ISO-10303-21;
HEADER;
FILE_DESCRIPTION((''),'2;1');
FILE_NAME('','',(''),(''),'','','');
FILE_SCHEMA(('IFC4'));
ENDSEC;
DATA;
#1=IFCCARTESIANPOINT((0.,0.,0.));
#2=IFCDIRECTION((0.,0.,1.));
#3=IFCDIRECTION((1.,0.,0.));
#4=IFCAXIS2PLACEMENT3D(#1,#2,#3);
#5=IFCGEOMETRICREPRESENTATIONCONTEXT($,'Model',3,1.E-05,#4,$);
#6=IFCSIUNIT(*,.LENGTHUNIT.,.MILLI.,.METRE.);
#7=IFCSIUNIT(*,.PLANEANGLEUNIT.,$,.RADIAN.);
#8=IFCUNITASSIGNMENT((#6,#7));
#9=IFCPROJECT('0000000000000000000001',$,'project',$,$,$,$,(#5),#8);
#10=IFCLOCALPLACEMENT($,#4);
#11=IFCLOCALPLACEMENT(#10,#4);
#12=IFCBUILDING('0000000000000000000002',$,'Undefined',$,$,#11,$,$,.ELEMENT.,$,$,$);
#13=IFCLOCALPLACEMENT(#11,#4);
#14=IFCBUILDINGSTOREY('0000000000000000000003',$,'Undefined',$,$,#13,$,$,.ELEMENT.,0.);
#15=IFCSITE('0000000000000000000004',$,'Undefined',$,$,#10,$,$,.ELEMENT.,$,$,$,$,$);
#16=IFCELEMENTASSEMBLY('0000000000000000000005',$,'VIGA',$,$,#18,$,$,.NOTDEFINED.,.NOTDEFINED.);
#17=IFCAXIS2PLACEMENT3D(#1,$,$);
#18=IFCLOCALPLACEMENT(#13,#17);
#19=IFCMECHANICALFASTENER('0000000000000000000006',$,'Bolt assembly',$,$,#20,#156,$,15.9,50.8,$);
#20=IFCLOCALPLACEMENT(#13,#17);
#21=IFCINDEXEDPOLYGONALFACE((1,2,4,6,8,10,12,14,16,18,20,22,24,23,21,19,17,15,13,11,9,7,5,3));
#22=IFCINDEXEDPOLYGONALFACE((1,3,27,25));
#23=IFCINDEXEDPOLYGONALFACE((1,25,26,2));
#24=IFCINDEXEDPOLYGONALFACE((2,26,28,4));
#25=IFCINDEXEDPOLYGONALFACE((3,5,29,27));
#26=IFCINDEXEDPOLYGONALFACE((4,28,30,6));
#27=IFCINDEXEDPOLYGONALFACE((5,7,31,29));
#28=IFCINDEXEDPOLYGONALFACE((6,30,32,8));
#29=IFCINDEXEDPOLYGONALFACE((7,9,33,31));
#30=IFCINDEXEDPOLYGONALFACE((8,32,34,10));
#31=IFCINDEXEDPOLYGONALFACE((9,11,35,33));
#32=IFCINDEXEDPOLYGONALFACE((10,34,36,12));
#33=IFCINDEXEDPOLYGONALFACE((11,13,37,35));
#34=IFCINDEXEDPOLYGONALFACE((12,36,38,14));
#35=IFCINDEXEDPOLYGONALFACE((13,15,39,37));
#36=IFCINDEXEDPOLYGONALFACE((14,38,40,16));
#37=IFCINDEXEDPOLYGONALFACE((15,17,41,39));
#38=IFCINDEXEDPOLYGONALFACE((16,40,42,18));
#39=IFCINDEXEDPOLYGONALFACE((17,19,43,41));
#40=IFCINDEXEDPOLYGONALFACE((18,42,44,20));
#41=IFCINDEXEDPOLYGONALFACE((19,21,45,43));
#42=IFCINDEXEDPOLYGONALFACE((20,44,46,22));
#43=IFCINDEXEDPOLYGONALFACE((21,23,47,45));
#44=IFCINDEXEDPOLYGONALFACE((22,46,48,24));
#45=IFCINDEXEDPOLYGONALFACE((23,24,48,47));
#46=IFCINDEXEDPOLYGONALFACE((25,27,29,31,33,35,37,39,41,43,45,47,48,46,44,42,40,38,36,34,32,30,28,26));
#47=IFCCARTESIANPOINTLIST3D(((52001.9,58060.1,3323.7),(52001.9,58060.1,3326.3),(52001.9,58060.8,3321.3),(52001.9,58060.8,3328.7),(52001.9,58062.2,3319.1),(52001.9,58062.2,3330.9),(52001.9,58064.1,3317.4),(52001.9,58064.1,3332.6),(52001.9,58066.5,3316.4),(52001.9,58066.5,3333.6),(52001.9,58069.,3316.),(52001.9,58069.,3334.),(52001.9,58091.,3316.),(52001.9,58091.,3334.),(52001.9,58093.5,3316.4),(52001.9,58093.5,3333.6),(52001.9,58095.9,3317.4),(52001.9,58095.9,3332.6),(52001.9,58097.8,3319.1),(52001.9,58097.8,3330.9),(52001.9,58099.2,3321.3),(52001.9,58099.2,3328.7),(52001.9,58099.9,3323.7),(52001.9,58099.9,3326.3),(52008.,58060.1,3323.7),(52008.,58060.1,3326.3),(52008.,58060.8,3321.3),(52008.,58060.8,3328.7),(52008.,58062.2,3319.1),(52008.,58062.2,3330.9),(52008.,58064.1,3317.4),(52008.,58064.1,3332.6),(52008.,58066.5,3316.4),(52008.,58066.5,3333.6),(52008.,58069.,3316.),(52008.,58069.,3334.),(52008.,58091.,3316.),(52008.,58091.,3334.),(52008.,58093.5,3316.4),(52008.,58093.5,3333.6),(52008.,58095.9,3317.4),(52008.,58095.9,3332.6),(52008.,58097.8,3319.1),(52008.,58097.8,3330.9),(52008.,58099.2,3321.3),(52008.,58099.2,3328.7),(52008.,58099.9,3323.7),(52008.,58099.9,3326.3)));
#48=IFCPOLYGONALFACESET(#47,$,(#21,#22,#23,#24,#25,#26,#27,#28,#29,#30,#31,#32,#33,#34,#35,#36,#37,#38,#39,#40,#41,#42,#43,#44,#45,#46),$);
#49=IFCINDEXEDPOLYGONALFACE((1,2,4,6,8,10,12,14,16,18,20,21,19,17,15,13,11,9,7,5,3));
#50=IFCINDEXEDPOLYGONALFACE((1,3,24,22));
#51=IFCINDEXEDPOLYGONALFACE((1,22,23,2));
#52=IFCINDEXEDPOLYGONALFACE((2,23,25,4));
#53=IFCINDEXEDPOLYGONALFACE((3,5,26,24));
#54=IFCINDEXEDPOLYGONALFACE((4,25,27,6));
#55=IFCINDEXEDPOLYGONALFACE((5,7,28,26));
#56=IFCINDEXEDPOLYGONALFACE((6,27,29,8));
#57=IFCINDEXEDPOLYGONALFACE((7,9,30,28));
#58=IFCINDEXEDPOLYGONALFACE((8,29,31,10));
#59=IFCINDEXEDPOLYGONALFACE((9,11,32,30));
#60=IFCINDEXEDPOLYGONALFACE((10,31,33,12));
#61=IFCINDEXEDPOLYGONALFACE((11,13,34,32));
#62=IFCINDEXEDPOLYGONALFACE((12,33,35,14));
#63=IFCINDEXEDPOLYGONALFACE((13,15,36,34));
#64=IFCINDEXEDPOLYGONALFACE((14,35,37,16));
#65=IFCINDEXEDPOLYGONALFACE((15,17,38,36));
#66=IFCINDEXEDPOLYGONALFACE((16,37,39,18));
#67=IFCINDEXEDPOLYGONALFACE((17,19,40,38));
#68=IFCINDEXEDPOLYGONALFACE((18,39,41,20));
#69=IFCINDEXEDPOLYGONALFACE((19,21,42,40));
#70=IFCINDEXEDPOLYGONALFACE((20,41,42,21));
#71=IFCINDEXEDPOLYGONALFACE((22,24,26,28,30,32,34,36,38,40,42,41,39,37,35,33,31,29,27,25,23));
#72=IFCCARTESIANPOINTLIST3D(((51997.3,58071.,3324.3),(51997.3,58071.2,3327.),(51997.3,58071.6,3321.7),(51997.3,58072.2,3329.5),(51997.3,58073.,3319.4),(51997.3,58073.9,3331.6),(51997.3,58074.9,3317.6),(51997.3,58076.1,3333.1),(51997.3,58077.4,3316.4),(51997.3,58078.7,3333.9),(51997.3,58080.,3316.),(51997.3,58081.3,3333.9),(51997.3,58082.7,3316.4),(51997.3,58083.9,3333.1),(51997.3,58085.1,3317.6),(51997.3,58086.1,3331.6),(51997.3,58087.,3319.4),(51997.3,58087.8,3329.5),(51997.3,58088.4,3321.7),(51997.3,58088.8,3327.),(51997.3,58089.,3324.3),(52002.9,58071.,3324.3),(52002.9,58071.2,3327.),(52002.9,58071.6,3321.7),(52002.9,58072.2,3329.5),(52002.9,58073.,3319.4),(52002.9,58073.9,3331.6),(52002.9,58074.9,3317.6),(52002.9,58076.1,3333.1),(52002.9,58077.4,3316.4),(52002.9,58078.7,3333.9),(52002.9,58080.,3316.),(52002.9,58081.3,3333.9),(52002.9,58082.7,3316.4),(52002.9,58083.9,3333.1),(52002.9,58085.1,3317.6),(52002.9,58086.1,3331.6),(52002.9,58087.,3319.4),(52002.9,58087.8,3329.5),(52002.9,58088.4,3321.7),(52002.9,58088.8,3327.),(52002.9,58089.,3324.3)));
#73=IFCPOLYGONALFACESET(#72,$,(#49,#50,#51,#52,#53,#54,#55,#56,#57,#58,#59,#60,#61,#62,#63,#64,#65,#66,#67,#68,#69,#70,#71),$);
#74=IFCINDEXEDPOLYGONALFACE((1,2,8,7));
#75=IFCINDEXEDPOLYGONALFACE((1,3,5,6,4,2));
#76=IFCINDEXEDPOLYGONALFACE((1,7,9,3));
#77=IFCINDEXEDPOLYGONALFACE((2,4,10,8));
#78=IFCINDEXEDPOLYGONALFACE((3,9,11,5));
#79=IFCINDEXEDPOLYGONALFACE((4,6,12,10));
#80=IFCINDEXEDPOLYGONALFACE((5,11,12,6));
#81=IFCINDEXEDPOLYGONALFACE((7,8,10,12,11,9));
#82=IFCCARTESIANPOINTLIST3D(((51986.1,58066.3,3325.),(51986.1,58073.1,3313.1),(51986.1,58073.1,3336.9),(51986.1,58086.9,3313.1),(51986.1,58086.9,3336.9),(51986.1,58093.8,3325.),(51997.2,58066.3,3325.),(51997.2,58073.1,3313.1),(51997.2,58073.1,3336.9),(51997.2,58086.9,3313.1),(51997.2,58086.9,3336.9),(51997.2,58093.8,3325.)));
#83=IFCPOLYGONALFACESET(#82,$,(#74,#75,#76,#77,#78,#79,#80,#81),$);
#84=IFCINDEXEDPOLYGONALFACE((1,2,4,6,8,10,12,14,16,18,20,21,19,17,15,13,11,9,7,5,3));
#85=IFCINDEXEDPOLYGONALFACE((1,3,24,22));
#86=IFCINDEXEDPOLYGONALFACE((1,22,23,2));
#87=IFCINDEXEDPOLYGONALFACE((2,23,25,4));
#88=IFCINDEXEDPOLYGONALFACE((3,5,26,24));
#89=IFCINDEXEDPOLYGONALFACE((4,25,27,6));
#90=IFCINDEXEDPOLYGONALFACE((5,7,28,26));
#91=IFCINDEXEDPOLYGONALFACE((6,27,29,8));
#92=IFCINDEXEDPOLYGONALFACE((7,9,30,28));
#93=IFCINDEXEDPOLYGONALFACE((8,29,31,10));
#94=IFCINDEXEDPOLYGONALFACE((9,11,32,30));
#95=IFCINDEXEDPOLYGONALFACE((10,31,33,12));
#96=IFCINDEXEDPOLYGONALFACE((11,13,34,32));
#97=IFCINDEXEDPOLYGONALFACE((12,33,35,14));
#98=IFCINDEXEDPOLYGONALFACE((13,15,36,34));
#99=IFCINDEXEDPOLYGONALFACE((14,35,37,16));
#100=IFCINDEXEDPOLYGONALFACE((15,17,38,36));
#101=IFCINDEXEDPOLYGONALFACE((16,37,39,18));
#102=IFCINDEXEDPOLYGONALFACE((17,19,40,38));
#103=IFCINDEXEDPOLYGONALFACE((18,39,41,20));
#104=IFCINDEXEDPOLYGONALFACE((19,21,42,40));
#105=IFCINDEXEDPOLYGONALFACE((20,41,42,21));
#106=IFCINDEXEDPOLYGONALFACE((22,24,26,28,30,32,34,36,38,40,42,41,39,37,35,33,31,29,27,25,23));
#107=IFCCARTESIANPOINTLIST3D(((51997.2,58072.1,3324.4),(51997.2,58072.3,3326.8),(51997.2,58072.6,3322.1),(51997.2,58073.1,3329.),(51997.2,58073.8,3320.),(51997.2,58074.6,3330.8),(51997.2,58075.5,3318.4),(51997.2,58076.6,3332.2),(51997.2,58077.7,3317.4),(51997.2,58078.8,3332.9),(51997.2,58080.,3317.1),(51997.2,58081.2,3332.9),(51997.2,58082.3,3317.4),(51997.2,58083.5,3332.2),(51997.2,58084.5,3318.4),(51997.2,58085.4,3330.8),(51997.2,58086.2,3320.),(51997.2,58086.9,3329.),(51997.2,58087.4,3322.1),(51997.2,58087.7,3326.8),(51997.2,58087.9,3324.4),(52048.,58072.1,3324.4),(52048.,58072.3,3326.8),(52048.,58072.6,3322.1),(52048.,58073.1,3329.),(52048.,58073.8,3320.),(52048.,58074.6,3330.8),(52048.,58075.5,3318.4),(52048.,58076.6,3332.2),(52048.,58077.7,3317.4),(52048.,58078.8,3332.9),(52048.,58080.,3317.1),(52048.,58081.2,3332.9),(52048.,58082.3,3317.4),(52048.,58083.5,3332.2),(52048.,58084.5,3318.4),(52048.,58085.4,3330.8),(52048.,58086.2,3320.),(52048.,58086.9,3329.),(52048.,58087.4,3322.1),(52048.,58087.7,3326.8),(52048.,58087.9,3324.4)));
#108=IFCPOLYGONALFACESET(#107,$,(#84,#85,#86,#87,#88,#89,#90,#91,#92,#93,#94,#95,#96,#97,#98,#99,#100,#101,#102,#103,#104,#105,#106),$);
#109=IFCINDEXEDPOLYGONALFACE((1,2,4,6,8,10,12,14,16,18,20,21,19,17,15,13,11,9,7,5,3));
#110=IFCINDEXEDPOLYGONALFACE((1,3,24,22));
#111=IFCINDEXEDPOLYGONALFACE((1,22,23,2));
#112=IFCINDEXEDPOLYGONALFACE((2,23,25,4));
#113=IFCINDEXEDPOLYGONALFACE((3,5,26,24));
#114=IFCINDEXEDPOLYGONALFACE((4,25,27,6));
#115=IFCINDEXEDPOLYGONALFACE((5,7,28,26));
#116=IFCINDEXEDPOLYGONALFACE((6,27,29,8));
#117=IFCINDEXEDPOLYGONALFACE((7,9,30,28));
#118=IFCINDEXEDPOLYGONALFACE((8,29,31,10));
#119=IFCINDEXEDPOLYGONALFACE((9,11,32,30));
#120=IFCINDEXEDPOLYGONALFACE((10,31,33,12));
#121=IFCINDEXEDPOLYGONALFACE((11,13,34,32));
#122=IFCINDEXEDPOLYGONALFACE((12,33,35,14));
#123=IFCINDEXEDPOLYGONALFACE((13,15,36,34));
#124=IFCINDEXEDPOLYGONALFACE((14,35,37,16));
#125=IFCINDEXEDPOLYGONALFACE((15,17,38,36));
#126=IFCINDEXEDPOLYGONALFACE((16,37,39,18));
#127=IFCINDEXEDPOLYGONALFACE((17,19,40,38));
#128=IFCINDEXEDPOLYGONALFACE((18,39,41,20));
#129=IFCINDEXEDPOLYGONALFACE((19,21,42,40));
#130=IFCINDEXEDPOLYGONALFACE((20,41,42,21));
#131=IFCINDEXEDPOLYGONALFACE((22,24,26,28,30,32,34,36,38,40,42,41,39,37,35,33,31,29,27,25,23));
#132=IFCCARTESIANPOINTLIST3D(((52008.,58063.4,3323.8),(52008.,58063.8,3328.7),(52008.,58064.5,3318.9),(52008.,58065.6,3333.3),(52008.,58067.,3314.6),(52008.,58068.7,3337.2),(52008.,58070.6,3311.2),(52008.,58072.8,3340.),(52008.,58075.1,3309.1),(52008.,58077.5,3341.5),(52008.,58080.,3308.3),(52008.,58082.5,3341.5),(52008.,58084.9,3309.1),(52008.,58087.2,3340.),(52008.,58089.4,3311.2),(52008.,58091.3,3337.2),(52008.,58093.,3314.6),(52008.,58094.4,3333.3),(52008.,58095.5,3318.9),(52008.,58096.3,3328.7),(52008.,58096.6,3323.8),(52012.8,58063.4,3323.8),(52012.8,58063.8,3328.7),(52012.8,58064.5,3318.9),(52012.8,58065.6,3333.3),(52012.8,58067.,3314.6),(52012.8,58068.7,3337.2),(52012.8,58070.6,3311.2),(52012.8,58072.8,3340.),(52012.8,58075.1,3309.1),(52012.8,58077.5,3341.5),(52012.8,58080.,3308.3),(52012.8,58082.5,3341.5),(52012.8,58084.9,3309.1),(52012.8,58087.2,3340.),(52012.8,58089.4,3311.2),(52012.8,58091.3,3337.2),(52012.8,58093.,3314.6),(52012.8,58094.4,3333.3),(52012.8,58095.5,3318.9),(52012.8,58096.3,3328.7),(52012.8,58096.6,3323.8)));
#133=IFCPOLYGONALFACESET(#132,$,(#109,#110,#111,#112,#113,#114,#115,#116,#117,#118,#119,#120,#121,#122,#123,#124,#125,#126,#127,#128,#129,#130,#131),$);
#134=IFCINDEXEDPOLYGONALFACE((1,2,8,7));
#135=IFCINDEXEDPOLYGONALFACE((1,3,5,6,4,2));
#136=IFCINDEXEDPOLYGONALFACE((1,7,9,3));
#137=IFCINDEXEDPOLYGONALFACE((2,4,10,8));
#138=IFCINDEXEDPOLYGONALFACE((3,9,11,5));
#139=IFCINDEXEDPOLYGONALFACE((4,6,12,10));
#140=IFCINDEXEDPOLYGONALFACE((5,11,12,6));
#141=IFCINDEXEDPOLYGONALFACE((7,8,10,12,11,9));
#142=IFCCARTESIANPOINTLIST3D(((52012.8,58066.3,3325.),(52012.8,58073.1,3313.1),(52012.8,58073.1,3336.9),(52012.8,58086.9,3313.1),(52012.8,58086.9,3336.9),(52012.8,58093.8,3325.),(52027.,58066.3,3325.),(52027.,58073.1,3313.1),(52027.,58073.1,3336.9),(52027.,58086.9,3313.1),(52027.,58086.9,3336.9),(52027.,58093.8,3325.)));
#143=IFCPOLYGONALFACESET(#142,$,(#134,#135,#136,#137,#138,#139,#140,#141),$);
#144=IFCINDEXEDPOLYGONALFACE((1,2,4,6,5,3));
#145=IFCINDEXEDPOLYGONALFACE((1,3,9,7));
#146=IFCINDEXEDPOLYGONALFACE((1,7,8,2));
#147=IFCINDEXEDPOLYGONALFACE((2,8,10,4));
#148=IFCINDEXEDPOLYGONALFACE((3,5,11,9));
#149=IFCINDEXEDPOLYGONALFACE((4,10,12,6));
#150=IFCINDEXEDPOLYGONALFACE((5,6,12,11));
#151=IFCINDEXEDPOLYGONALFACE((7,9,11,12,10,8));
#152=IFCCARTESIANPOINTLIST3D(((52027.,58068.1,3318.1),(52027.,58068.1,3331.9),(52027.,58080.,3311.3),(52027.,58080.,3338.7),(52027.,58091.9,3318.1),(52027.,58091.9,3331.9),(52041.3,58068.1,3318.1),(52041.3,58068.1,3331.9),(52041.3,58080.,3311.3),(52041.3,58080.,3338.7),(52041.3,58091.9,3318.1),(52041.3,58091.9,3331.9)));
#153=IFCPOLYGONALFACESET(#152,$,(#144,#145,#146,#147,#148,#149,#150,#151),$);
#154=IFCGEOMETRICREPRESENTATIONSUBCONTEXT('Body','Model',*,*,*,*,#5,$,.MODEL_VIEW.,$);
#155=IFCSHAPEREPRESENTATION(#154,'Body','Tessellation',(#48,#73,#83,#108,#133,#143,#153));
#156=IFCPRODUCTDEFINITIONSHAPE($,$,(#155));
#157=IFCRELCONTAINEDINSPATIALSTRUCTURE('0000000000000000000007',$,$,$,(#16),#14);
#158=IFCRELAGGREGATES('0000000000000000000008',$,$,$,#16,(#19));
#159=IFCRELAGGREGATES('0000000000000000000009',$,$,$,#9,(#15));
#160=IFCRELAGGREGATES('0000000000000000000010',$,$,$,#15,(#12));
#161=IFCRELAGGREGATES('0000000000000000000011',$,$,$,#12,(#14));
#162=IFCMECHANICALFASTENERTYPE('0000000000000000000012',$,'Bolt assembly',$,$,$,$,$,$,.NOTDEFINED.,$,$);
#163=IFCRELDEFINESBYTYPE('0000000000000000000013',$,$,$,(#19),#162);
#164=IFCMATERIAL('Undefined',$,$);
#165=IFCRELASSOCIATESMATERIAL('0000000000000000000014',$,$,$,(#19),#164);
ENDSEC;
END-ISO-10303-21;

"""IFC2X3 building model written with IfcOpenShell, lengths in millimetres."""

from ifc_helpers import new_model, si_unit, frame, frame_2d, origin_with_axes, origin_2d_with_axis, place, context, subcontext, project, spatial, polyline, circle_curve, parameter, trimmed, segment, composite_curve, circle, outline, extrude, source, transform, mapped, material, type_object, element, aggregate, save


model = new_model("IFC2X3")

# Units and contexts
model_context = context("Model", 3, precision=1e-05, world=origin_with_axes())
body_context = subcontext(model_context, "Body", "Model", "MODEL_VIEW")
ifc_project = project(units=[si_unit("LENGTHUNIT", "METRE", prefix="MILLI"), si_unit("PLANEANGLEUNIT", "RADIAN")], contexts=[model_context])

# Site, building, storey
site_placement = place(None, origin_with_axes())
site = spatial("IfcSite", under=ifc_project, at=site_placement, Name="Undefined", CompositionType="ELEMENT")
building_placement = place(site_placement, origin_with_axes())
building = spatial("IfcBuilding", under=site, at=building_placement, Name="Undefined", CompositionType="ELEMENT")
storey_placement = place(building_placement, origin_with_axes())
storey = spatial("IfcBuildingStorey", under=building, at=storey_placement, Name="Undefined", CompositionType="ELEMENT", Elevation=0.0)

# Shared definitions
ifc_material_1 = material(Name="Undefined")
mechanical_fastener_type = type_object("IfcMechanicalFastenerType", Name="Bolt assembly")

# Element assembly, mechanical fastener
assembly_1_placement = place(storey_placement, origin_with_axes())
assembly_1 = element("IfcElementAssembly", 1, at=assembly_1_placement, inside=storey, Name="VIGA", AssemblyPlace="NOTDEFINED", PredefinedType="NOTDEFINED")
shared_shape_1 = source(origin_with_axes(), body_context, "Body", "SweptSolid", [
    extrude(outline(composite_curve([segment(polyline([(9.0, 11.0), (9.0, -11.0)]), True, "CONTINUOUS"), segment(trimmed(circle_curve(frame_2d((0.0, -11.0), x_axis=(1.0, 0.0)), 9.0), [parameter(0.0)], [parameter(3.141593)], False, "PARAMETER"), True, "CONTINUOUS"), segment(polyline([(-9.0, -11.0), (-9.0, 11.0)]), True, "CONTINUOUS"), segment(trimmed(circle_curve(frame_2d((0.0, 11.0), x_axis=(-1.0, 0.0)), 9.0), [parameter(0.0)], [parameter(3.141593)], False, "PARAMETER"), True, "DISCONTINUOUS")], self_intersect=False)), frame((0.0, 1.9, 0.0), z_axis=(0.0, 1.0, 0.0), x_axis=(1.0, 0.0, 0.0)), (0.0, 0.0, 1.0), 6.1),
    extrude(circle(Radius=9.0, at=origin_2d_with_axis()), frame((0.0, -2.7, 0.0), z_axis=(0.0, 1.0, 0.0), x_axis=(1.0, 0.0, 0.0)), (0.0, 0.0, 1.0), 5.6),
    extrude(outline(polyline([(11.9, -6.9), (11.9, 6.9), (0.0, 13.7), (-11.9, 6.9), (-11.9, -6.9), (0.0, -13.7), (11.9, -6.9)])), frame((0.0, -13.9, 0.0), z_axis=(0.0, 1.0, 0.0), x_axis=(1.0, 0.0, 0.0)), (0.0, 0.0, 1.0), 11.1),
    extrude(circle(Radius=7.9, at=origin_2d_with_axis()), frame((0.0, -2.8, 0.0), z_axis=(0.0, 1.0, 0.0), x_axis=(1.0, 0.0, 0.0)), (0.0, 0.0, 1.0), 50.8),
    extrude(circle(Radius=16.7, at=origin_2d_with_axis()), frame((0.0, 8.0, 0.0), z_axis=(0.0, 1.0, 0.0), x_axis=(1.0, 0.0, 0.0)), (0.0, 0.0, 1.0), 4.8),
    extrude(outline(polyline([(11.9, -6.9), (11.9, 6.9), (0.0, 13.7), (-11.9, 6.9), (-11.9, -6.9), (0.0, -13.7), (11.9, -6.9)])), frame((0.0, 12.8, 0.0), z_axis=(0.0, 1.0, 0.0), x_axis=(1.0, 0.0, 0.0)), (0.0, 0.0, 1.0), 14.3),
    extrude(outline(polyline([(13.7, 0.0), (6.9, 11.9), (-6.9, 11.9), (-13.7, 0.0), (-6.9, -11.9), (6.9, -11.9), (13.7, 0.0)])), frame((0.0, 27.0, 0.0), z_axis=(0.0, 1.0, 0.0), x_axis=(1.0, 0.0, 0.0)), (0.0, 0.0, 1.0), 14.3),
])
mechanical_fastener_1_placement = place(assembly_1_placement, frame((52000.0, 58080.0, 3325.0), z_axis=(0.0, -1.0, 0.0), x_axis=(0.0, 0.0, -1.0)))
mechanical_fastener_1 = element("IfcMechanicalFastener", 2, at=mechanical_fastener_1_placement, type_object=mechanical_fastener_type, material=ifc_material_1, Name="Bolt assembly", NominalDiameter=15.9, NominalLength=50.8, context=body_context, shape_type="MappedRepresentation", body=[
    mapped(shared_shape_1, transform((0.0, 0.0, 0.0))),
])
aggregate(assembly_1, [mechanical_fastener_1])

save(model, "model.ifc")
